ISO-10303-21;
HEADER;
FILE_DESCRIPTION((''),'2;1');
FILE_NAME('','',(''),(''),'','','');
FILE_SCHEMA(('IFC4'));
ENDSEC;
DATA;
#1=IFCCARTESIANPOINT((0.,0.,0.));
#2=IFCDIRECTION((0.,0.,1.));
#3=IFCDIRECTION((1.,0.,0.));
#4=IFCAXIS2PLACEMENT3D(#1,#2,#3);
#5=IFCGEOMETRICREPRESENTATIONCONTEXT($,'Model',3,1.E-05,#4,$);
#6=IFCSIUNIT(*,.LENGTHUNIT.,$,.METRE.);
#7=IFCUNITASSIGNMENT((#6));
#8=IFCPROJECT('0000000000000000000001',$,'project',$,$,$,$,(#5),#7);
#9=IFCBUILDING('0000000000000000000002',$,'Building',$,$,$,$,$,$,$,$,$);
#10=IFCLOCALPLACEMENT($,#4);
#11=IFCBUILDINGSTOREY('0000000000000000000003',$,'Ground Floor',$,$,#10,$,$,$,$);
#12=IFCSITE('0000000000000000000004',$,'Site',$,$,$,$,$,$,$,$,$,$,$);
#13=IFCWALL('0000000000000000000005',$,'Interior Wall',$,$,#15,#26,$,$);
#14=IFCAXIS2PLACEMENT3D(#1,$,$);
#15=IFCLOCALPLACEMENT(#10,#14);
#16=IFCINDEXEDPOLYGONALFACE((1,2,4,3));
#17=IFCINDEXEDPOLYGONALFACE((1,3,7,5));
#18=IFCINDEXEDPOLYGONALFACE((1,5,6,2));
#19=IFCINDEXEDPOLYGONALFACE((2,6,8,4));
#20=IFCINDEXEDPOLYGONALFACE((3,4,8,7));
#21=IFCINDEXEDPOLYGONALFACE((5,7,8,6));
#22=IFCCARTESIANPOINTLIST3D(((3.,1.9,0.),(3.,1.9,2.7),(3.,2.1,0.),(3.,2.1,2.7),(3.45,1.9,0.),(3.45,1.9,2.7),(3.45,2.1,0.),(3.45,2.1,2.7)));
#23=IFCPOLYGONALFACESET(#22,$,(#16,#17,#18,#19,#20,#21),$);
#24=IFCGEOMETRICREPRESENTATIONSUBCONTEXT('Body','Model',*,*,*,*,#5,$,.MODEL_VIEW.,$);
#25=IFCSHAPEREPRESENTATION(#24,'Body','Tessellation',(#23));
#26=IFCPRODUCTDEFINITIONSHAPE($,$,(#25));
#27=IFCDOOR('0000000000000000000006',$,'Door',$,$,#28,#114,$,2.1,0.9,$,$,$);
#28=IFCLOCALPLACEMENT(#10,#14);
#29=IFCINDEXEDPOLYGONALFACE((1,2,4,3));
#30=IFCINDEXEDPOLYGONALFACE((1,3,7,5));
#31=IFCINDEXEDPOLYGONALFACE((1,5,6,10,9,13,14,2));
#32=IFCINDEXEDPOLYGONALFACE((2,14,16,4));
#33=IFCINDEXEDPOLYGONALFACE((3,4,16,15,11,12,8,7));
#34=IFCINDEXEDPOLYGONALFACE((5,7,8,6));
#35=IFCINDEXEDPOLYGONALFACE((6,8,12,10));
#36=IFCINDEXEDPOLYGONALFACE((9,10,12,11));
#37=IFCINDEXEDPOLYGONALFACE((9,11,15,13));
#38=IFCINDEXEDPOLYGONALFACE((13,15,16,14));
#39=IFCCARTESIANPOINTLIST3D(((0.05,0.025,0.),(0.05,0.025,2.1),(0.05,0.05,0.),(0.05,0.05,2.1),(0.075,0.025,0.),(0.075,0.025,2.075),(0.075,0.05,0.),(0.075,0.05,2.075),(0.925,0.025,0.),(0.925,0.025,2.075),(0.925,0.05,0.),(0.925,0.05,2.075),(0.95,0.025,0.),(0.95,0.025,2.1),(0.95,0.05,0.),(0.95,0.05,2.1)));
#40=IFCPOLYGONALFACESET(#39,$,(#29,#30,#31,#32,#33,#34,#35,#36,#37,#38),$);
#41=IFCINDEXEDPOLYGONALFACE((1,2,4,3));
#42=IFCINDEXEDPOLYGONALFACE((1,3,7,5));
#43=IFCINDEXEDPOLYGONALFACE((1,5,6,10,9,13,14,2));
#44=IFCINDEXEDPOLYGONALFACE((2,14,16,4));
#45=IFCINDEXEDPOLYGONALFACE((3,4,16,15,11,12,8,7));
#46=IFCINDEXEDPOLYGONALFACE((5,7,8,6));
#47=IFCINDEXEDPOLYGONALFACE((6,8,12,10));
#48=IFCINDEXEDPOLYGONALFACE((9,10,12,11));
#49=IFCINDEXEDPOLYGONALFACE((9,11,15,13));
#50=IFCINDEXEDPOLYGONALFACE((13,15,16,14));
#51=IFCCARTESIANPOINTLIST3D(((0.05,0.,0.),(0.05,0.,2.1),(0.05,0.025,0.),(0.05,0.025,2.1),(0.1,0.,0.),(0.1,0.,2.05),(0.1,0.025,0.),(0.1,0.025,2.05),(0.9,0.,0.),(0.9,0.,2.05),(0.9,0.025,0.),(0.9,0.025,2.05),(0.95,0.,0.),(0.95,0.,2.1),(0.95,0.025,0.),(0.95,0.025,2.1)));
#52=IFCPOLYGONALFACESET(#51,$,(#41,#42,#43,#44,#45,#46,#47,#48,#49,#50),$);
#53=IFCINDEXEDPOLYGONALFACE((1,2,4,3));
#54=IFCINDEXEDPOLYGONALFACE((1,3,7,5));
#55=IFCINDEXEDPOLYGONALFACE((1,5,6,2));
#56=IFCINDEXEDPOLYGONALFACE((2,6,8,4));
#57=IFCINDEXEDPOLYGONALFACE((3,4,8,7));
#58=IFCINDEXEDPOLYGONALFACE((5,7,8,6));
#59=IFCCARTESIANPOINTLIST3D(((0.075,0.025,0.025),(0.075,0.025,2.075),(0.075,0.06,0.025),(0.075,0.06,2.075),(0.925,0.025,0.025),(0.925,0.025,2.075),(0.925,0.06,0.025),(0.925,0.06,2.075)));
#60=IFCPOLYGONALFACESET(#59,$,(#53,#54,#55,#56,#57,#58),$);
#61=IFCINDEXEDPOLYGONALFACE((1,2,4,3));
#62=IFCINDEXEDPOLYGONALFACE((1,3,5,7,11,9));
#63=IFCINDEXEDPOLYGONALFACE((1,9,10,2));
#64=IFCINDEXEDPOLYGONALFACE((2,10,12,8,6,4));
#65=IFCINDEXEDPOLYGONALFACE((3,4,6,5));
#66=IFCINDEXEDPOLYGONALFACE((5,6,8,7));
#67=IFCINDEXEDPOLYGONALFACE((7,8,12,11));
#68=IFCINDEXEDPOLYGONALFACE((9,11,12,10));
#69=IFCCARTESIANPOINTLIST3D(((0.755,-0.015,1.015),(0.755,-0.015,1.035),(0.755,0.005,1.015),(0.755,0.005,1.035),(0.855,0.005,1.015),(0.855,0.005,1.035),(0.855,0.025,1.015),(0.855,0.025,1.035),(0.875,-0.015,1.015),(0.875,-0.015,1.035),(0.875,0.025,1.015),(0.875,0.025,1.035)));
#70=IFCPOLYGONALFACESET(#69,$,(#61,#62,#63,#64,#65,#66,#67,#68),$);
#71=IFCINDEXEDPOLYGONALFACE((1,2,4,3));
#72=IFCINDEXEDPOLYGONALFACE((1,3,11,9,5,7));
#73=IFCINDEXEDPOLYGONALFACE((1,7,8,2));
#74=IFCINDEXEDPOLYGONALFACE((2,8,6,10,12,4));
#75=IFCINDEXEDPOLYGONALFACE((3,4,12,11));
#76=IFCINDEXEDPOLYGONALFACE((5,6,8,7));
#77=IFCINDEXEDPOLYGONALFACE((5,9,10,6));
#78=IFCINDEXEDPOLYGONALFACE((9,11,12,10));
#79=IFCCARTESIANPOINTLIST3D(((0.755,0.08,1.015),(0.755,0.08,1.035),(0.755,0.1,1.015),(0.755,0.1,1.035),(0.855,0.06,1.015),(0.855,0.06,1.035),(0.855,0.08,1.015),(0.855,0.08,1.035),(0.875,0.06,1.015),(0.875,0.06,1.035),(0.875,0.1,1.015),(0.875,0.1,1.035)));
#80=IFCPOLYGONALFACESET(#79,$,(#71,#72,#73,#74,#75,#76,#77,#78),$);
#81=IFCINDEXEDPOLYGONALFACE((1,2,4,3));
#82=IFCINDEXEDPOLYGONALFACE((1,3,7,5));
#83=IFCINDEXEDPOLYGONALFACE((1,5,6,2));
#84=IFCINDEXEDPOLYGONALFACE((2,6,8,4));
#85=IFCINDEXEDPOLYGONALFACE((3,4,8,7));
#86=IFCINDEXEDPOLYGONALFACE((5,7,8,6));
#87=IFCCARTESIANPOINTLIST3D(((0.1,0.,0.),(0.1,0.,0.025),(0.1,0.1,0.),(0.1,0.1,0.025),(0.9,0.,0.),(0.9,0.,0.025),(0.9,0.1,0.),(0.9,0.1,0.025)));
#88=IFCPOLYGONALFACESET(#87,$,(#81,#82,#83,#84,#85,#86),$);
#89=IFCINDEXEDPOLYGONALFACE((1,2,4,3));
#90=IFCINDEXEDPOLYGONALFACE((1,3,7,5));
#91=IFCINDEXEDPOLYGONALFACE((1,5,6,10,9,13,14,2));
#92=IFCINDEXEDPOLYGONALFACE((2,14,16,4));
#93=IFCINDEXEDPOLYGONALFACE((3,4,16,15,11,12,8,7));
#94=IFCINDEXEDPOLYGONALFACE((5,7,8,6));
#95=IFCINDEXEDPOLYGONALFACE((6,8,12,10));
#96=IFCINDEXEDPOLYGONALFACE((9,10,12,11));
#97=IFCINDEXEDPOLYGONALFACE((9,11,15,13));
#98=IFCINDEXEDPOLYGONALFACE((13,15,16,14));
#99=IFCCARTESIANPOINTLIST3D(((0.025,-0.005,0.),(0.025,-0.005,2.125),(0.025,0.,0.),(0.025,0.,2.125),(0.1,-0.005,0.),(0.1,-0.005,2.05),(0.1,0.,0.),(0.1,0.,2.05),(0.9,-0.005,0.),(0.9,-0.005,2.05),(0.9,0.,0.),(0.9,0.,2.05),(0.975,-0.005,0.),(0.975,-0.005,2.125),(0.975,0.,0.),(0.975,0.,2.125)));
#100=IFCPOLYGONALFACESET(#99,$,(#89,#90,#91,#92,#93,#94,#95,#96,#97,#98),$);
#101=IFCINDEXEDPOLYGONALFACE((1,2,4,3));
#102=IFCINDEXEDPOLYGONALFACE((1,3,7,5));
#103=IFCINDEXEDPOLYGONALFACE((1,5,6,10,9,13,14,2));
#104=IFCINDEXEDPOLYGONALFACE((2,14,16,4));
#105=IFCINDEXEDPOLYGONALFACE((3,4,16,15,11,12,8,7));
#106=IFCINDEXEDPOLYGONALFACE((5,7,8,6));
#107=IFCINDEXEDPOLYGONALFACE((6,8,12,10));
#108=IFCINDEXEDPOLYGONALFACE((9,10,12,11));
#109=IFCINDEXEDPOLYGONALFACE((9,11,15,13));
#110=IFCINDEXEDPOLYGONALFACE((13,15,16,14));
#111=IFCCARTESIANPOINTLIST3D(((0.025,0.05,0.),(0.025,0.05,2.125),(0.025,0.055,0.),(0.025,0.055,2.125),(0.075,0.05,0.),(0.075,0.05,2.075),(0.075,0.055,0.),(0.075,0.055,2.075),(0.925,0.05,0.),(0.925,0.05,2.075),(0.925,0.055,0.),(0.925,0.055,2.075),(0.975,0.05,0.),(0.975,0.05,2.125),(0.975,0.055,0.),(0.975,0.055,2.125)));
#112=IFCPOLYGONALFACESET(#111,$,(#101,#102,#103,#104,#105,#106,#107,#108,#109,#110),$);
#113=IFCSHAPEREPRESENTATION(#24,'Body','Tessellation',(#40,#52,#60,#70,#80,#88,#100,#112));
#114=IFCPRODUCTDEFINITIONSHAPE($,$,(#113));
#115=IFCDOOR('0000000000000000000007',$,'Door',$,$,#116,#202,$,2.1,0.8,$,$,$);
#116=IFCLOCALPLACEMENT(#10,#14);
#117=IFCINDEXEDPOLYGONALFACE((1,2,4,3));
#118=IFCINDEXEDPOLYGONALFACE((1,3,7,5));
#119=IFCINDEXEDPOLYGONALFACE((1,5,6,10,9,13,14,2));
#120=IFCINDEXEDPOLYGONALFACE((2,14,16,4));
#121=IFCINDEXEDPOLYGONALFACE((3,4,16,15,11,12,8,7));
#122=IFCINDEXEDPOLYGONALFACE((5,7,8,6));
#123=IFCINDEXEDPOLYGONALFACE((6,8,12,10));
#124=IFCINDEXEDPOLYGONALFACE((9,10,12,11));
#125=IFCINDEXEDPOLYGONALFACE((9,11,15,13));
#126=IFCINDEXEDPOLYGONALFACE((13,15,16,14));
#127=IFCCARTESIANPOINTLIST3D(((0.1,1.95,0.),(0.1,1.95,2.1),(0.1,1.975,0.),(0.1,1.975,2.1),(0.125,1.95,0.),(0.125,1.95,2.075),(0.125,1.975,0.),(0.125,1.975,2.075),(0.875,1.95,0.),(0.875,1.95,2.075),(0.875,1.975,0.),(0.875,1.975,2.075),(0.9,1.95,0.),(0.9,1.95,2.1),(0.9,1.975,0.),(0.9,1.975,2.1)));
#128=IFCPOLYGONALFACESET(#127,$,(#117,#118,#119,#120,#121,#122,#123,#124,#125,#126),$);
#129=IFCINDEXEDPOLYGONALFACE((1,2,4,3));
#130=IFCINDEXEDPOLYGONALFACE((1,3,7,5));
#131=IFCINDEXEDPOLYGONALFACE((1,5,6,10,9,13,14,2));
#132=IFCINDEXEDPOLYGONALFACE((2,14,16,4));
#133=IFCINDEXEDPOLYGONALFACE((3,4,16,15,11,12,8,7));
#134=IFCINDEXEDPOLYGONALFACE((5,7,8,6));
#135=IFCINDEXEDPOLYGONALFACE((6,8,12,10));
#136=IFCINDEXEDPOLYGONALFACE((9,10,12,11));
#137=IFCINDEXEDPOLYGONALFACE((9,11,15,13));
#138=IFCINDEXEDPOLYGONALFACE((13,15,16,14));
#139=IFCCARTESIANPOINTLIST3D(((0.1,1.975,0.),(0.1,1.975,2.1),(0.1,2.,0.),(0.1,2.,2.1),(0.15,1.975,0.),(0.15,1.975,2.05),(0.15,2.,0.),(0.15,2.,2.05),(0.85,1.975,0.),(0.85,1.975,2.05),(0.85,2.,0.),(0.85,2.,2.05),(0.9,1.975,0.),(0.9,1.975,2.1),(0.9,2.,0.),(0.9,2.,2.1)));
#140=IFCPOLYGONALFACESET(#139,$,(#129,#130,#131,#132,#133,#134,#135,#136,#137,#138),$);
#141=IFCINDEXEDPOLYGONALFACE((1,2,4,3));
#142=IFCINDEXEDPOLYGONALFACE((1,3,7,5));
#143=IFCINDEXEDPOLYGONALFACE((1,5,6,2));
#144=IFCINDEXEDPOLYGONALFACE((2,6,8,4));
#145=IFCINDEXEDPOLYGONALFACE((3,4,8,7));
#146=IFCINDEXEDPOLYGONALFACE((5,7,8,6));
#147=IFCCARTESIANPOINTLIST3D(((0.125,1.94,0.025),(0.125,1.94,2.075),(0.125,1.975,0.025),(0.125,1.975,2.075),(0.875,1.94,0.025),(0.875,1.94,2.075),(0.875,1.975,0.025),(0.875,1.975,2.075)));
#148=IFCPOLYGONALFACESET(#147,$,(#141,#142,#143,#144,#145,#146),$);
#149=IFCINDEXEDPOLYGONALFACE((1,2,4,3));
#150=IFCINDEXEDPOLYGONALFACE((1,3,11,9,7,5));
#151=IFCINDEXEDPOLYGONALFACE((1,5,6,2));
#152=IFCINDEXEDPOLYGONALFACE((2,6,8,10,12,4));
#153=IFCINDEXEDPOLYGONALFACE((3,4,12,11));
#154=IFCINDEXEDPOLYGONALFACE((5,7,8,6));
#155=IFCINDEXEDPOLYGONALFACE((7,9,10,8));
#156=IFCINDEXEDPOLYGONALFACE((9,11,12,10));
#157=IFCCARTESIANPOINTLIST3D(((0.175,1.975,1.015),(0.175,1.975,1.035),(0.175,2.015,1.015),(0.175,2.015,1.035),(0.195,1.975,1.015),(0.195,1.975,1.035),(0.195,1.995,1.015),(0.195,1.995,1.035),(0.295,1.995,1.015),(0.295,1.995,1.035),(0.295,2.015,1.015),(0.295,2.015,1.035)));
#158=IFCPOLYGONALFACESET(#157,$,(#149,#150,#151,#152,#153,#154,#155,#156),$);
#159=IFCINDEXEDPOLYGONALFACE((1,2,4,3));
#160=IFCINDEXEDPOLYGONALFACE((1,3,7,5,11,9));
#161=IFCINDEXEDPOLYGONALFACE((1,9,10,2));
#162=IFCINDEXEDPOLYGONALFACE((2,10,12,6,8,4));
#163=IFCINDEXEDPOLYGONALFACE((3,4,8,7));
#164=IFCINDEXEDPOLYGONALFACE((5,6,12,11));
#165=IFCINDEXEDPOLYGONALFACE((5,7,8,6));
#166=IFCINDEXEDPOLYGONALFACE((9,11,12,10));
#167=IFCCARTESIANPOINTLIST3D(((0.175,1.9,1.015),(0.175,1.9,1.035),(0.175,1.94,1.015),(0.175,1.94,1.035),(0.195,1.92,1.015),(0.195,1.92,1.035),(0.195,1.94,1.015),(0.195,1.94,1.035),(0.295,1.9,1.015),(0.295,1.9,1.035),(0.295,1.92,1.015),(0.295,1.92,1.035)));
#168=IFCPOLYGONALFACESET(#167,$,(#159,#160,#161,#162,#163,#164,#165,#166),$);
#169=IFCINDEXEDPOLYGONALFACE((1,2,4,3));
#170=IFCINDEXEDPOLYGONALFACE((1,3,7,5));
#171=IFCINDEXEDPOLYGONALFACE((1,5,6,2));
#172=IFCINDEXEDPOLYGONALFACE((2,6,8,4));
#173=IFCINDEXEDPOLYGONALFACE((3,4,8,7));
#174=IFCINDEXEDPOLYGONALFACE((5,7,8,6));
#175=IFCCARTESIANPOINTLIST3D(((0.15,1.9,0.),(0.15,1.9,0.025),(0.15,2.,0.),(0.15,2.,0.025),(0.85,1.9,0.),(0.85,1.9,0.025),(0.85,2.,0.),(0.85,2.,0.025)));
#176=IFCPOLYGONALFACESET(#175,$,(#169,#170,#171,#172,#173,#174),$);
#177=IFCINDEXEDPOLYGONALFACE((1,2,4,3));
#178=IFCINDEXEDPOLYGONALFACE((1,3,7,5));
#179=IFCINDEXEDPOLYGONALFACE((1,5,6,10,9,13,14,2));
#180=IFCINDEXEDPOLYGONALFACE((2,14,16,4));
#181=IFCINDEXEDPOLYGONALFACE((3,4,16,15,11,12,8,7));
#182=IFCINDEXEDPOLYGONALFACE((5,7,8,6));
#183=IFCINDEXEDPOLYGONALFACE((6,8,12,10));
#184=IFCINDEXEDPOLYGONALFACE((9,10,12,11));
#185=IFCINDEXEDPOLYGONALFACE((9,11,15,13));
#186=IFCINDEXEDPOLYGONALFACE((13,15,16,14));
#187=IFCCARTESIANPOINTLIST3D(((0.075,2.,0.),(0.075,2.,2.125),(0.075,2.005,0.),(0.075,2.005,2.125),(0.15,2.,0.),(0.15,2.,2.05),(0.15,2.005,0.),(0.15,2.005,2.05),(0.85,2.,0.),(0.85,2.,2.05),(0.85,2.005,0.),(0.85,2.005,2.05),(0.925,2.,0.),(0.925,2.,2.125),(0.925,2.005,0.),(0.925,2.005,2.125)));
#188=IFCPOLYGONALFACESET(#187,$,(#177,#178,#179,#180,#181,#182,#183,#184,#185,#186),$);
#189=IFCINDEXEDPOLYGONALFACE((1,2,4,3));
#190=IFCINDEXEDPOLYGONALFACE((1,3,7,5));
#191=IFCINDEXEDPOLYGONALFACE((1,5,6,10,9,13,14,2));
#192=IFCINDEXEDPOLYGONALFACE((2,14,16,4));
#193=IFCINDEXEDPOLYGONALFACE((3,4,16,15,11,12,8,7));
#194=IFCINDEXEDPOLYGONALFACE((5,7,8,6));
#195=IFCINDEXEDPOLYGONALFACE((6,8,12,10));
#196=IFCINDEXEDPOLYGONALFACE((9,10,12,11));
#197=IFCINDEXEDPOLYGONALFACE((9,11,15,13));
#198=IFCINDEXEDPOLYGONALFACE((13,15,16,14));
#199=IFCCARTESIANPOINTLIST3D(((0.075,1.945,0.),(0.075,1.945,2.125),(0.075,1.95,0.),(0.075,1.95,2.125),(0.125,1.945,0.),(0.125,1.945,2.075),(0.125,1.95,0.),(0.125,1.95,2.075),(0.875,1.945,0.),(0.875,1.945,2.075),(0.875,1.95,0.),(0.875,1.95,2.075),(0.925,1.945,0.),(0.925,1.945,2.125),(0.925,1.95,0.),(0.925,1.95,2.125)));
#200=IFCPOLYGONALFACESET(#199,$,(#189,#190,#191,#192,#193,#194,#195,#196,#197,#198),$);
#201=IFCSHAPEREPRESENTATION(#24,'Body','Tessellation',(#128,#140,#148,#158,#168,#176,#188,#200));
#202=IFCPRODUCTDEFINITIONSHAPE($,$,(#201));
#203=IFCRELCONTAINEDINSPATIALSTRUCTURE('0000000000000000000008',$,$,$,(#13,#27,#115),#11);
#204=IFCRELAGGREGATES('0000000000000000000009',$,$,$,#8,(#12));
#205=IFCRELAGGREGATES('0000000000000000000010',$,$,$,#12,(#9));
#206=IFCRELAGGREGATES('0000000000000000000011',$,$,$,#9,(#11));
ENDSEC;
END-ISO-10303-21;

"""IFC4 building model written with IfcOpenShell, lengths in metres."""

from ifc_helpers import new_model, si_unit, frame, origin_with_axes, place, context, subcontext, project, spatial, line, indexed_curve, outline, extrude, element, save


model = new_model("IFC4")

# Units and contexts
model_context = context("Model", 3, precision=1e-05, world=origin_with_axes())
body_context = subcontext(model_context, "Body", "Model", "MODEL_VIEW")
ifc_project = project(units=[si_unit("LENGTHUNIT", "METRE")], contexts=[model_context])

# Site, building, storey
site = spatial("IfcSite", under=ifc_project, Name="Site")
building = spatial("IfcBuilding", under=site, Name="Building")
storey_placement = place(None, origin_with_axes())
storey = spatial("IfcBuildingStorey", under=building, at=storey_placement, Name="Ground Floor")

# Wall
for number, where, z_axis, x_axis, name in (
    (1, (3.45, 2.0, 0.0), (0.0, 0.0, 1.0), (-1.0, 0.0, 0.0), "Interior Wall"),
):
    element("IfcWall", number, at=place(storey_placement, frame(where, z_axis=z_axis, x_axis=x_axis)), inside=storey, Name=name, context=body_context, shape_type="SweptSolid", body=[
        extrude(outline(indexed_curve([(0.0, 0.0), (0.0, 0.2), (0.45, 0.2), (0.45, 0.0), (0.0, 0.0)], self_intersect=False)), frame((0.0, -0.1, 0.0), z_axis=(0.0, 0.0, 1.0), x_axis=(1.0, 0.0, 0.0)), (0.0, 0.0, 1.0), 2.7),
    ])

# Doors
door_1_placement = place(storey_placement, frame((0.05, 0.0, 0.0), z_axis=(0.0, 0.0, 1.0), x_axis=(1.0, 0.0, 0.0)))
element("IfcDoor", 2, at=door_1_placement, inside=storey, Name="Door", OverallHeight=2.1, OverallWidth=0.9, context=body_context, shape_type="SweptSolid", body=[
    extrude(outline(indexed_curve([(0.0, 0.0), (0.0, 2.1), (0.9, 2.1), (0.9, 0.0), (0.875, 0.0), (0.875, 2.075), (0.025, 2.075), (0.025, 0.0)], segments=[line(1, 2, 3, 4, 5, 6, 7, 8, 1)])), frame((0.0, 0.025, 0.0), z_axis=(0.0, -1.0, 0.0), x_axis=(1.0, 0.0, 0.0)), (0.0, 0.0, -1.0), 0.025),
    extrude(outline(indexed_curve([(0.0, 0.0), (0.0, 2.1), (0.9, 2.1), (0.9, 0.0), (0.85, 0.0), (0.85, 2.05), (0.05, 2.05), (0.05, 0.0)], segments=[line(1, 2, 3, 4, 5, 6, 7, 8, 1)])), frame((0.0, 0.0, 0.0), z_axis=(0.0, -1.0, 0.0), x_axis=(1.0, 0.0, 0.0)), (0.0, 0.0, -1.0), 0.025),
    extrude(outline(indexed_curve([(0.0, 0.0), (0.85, 0.0), (0.85, 0.035), (0.0, 0.035)], segments=[line(1, 2, 3, 4, 1)])), frame((0.025, 0.025, 0.025), z_axis=(0.0, 0.0, 1.0), x_axis=(1.0, 0.0, 0.0)), (0.0, 0.0, 1.0), 2.05),
    extrude(outline(indexed_curve([(0.0, 0.0), (0.0, -0.04), (-0.12, -0.04), (-0.12, -0.02), (-0.02, -0.02), (-0.02, 0.0)], segments=[line(1, 2, 3, 4, 5, 6, 1)])), frame((0.825, 0.025, 1.015), z_axis=(0.0, 0.0, 1.0), x_axis=(1.0, 0.0, 0.0)), (0.0, 0.0, 1.0), 0.02),
    extrude(outline(indexed_curve([(0.0, 0.0), (0.0, 0.04), (-0.12, 0.04), (-0.12, 0.02), (-0.02, 0.02), (-0.02, 0.0)], segments=[line(1, 2, 3, 4, 5, 6, 1)])), frame((0.825, 0.06, 1.015), z_axis=(0.0, 0.0, 1.0), x_axis=(1.0, 0.0, 0.0)), (0.0, 0.0, 1.0), 0.02),
    extrude(outline(indexed_curve([(0.0, 0.0), (0.8, 0.0), (0.8, 0.1), (0.0, 0.1)], segments=[line(1, 2, 3, 4, 1)])), frame((0.05, 0.0, 0.0), z_axis=(0.0, 0.0, 1.0), x_axis=(1.0, 0.0, 0.0)), (0.0, 0.0, 1.0), 0.025),
    extrude(outline(indexed_curve([(0.0, 0.0), (0.0, 2.125), (0.95, 2.125), (0.95, 0.0), (0.875, 0.0), (0.875, 2.05), (0.075, 2.05), (0.075, 0.0)], segments=[line(1, 2, 3, 4, 5, 6, 7, 8, 1)])), frame((-0.025, -0.005, 0.0), z_axis=(0.0, -1.0, 0.0), x_axis=(1.0, 0.0, 0.0)), (0.0, 0.0, -1.0), 0.005),
    extrude(outline(indexed_curve([(0.0, 0.0), (0.0, 2.125), (0.95, 2.125), (0.95, 0.0), (0.9, 0.0), (0.9, 2.075), (0.05, 2.075), (0.05, 0.0)], segments=[line(1, 2, 3, 4, 5, 6, 7, 8, 1)])), frame((-0.025, 0.05, 0.0), z_axis=(0.0, -1.0, 0.0), x_axis=(1.0, 0.0, 0.0)), (0.0, 0.0, -1.0), 0.005),
])
door_2_placement = place(storey_placement, frame((0.9, 2.0, 0.0), z_axis=(0.0, 0.0, 1.0), x_axis=(-1.0, 0.0, 0.0)))
element("IfcDoor", 3, at=door_2_placement, inside=storey, Name="Door", OverallHeight=2.1, OverallWidth=0.8, context=body_context, shape_type="SweptSolid", body=[
    extrude(outline(indexed_curve([(0.0, 0.0), (0.0, 2.1), (0.8, 2.1), (0.8, 0.0), (0.775, 0.0), (0.775, 2.075), (0.025, 2.075), (0.025, 0.0)], segments=[line(1, 2, 3, 4, 5, 6, 7, 8, 1)])), frame((0.0, 0.025, 0.0), z_axis=(0.0, -1.0, 0.0), x_axis=(1.0, 0.0, 0.0)), (0.0, 0.0, -1.0), 0.025),
    extrude(outline(indexed_curve([(0.0, 0.0), (0.0, 2.1), (0.8, 2.1), (0.8, 0.0), (0.75, 0.0), (0.75, 2.05), (0.05, 2.05), (0.05, 0.0)], segments=[line(1, 2, 3, 4, 5, 6, 7, 8, 1)])), frame((0.0, 0.0, 0.0), z_axis=(0.0, -1.0, 0.0), x_axis=(1.0, 0.0, 0.0)), (0.0, 0.0, -1.0), 0.025),
    extrude(outline(indexed_curve([(0.0, 0.0), (0.75, 0.0), (0.75, 0.035), (0.0, 0.035)], segments=[line(1, 2, 3, 4, 1)])), frame((0.025, 0.025, 0.025), z_axis=(0.0, 0.0, 1.0), x_axis=(1.0, 0.0, 0.0)), (0.0, 0.0, 1.0), 2.05),
    extrude(outline(indexed_curve([(0.0, 0.0), (0.0, -0.04), (-0.12, -0.04), (-0.12, -0.02), (-0.02, -0.02), (-0.02, 0.0)], segments=[line(1, 2, 3, 4, 5, 6, 1)])), frame((0.725, 0.025, 1.015), z_axis=(0.0, 0.0, 1.0), x_axis=(1.0, 0.0, 0.0)), (0.0, 0.0, 1.0), 0.02),
    extrude(outline(indexed_curve([(0.0, 0.0), (0.0, 0.04), (-0.12, 0.04), (-0.12, 0.02), (-0.02, 0.02), (-0.02, 0.0)], segments=[line(1, 2, 3, 4, 5, 6, 1)])), frame((0.725, 0.06, 1.015), z_axis=(0.0, 0.0, 1.0), x_axis=(1.0, 0.0, 0.0)), (0.0, 0.0, 1.0), 0.02),
    extrude(outline(indexed_curve([(0.0, 0.0), (0.7, 0.0), (0.7, 0.1), (0.0, 0.1)], segments=[line(1, 2, 3, 4, 1)])), frame((0.05, 0.0, 0.0), z_axis=(0.0, 0.0, 1.0), x_axis=(1.0, 0.0, 0.0)), (0.0, 0.0, 1.0), 0.025),
    extrude(outline(indexed_curve([(0.0, 0.0), (0.0, 2.125), (0.85, 2.125), (0.85, 0.0), (0.775, 0.0), (0.775, 2.05), (0.075, 2.05), (0.075, 0.0)], segments=[line(1, 2, 3, 4, 5, 6, 7, 8, 1)])), frame((-0.025, -0.005, 0.0), z_axis=(0.0, -1.0, 0.0), x_axis=(1.0, 0.0, 0.0)), (0.0, 0.0, -1.0), 0.005),
    extrude(outline(indexed_curve([(0.0, 0.0), (0.0, 2.125), (0.85, 2.125), (0.85, 0.0), (0.8, 0.0), (0.8, 2.075), (0.05, 2.075), (0.05, 0.0)], segments=[line(1, 2, 3, 4, 5, 6, 7, 8, 1)])), frame((-0.025, 0.05, 0.0), z_axis=(0.0, -1.0, 0.0), x_axis=(1.0, 0.0, 0.0)), (0.0, 0.0, -1.0), 0.005),
])

save(model, "model.ifc")
